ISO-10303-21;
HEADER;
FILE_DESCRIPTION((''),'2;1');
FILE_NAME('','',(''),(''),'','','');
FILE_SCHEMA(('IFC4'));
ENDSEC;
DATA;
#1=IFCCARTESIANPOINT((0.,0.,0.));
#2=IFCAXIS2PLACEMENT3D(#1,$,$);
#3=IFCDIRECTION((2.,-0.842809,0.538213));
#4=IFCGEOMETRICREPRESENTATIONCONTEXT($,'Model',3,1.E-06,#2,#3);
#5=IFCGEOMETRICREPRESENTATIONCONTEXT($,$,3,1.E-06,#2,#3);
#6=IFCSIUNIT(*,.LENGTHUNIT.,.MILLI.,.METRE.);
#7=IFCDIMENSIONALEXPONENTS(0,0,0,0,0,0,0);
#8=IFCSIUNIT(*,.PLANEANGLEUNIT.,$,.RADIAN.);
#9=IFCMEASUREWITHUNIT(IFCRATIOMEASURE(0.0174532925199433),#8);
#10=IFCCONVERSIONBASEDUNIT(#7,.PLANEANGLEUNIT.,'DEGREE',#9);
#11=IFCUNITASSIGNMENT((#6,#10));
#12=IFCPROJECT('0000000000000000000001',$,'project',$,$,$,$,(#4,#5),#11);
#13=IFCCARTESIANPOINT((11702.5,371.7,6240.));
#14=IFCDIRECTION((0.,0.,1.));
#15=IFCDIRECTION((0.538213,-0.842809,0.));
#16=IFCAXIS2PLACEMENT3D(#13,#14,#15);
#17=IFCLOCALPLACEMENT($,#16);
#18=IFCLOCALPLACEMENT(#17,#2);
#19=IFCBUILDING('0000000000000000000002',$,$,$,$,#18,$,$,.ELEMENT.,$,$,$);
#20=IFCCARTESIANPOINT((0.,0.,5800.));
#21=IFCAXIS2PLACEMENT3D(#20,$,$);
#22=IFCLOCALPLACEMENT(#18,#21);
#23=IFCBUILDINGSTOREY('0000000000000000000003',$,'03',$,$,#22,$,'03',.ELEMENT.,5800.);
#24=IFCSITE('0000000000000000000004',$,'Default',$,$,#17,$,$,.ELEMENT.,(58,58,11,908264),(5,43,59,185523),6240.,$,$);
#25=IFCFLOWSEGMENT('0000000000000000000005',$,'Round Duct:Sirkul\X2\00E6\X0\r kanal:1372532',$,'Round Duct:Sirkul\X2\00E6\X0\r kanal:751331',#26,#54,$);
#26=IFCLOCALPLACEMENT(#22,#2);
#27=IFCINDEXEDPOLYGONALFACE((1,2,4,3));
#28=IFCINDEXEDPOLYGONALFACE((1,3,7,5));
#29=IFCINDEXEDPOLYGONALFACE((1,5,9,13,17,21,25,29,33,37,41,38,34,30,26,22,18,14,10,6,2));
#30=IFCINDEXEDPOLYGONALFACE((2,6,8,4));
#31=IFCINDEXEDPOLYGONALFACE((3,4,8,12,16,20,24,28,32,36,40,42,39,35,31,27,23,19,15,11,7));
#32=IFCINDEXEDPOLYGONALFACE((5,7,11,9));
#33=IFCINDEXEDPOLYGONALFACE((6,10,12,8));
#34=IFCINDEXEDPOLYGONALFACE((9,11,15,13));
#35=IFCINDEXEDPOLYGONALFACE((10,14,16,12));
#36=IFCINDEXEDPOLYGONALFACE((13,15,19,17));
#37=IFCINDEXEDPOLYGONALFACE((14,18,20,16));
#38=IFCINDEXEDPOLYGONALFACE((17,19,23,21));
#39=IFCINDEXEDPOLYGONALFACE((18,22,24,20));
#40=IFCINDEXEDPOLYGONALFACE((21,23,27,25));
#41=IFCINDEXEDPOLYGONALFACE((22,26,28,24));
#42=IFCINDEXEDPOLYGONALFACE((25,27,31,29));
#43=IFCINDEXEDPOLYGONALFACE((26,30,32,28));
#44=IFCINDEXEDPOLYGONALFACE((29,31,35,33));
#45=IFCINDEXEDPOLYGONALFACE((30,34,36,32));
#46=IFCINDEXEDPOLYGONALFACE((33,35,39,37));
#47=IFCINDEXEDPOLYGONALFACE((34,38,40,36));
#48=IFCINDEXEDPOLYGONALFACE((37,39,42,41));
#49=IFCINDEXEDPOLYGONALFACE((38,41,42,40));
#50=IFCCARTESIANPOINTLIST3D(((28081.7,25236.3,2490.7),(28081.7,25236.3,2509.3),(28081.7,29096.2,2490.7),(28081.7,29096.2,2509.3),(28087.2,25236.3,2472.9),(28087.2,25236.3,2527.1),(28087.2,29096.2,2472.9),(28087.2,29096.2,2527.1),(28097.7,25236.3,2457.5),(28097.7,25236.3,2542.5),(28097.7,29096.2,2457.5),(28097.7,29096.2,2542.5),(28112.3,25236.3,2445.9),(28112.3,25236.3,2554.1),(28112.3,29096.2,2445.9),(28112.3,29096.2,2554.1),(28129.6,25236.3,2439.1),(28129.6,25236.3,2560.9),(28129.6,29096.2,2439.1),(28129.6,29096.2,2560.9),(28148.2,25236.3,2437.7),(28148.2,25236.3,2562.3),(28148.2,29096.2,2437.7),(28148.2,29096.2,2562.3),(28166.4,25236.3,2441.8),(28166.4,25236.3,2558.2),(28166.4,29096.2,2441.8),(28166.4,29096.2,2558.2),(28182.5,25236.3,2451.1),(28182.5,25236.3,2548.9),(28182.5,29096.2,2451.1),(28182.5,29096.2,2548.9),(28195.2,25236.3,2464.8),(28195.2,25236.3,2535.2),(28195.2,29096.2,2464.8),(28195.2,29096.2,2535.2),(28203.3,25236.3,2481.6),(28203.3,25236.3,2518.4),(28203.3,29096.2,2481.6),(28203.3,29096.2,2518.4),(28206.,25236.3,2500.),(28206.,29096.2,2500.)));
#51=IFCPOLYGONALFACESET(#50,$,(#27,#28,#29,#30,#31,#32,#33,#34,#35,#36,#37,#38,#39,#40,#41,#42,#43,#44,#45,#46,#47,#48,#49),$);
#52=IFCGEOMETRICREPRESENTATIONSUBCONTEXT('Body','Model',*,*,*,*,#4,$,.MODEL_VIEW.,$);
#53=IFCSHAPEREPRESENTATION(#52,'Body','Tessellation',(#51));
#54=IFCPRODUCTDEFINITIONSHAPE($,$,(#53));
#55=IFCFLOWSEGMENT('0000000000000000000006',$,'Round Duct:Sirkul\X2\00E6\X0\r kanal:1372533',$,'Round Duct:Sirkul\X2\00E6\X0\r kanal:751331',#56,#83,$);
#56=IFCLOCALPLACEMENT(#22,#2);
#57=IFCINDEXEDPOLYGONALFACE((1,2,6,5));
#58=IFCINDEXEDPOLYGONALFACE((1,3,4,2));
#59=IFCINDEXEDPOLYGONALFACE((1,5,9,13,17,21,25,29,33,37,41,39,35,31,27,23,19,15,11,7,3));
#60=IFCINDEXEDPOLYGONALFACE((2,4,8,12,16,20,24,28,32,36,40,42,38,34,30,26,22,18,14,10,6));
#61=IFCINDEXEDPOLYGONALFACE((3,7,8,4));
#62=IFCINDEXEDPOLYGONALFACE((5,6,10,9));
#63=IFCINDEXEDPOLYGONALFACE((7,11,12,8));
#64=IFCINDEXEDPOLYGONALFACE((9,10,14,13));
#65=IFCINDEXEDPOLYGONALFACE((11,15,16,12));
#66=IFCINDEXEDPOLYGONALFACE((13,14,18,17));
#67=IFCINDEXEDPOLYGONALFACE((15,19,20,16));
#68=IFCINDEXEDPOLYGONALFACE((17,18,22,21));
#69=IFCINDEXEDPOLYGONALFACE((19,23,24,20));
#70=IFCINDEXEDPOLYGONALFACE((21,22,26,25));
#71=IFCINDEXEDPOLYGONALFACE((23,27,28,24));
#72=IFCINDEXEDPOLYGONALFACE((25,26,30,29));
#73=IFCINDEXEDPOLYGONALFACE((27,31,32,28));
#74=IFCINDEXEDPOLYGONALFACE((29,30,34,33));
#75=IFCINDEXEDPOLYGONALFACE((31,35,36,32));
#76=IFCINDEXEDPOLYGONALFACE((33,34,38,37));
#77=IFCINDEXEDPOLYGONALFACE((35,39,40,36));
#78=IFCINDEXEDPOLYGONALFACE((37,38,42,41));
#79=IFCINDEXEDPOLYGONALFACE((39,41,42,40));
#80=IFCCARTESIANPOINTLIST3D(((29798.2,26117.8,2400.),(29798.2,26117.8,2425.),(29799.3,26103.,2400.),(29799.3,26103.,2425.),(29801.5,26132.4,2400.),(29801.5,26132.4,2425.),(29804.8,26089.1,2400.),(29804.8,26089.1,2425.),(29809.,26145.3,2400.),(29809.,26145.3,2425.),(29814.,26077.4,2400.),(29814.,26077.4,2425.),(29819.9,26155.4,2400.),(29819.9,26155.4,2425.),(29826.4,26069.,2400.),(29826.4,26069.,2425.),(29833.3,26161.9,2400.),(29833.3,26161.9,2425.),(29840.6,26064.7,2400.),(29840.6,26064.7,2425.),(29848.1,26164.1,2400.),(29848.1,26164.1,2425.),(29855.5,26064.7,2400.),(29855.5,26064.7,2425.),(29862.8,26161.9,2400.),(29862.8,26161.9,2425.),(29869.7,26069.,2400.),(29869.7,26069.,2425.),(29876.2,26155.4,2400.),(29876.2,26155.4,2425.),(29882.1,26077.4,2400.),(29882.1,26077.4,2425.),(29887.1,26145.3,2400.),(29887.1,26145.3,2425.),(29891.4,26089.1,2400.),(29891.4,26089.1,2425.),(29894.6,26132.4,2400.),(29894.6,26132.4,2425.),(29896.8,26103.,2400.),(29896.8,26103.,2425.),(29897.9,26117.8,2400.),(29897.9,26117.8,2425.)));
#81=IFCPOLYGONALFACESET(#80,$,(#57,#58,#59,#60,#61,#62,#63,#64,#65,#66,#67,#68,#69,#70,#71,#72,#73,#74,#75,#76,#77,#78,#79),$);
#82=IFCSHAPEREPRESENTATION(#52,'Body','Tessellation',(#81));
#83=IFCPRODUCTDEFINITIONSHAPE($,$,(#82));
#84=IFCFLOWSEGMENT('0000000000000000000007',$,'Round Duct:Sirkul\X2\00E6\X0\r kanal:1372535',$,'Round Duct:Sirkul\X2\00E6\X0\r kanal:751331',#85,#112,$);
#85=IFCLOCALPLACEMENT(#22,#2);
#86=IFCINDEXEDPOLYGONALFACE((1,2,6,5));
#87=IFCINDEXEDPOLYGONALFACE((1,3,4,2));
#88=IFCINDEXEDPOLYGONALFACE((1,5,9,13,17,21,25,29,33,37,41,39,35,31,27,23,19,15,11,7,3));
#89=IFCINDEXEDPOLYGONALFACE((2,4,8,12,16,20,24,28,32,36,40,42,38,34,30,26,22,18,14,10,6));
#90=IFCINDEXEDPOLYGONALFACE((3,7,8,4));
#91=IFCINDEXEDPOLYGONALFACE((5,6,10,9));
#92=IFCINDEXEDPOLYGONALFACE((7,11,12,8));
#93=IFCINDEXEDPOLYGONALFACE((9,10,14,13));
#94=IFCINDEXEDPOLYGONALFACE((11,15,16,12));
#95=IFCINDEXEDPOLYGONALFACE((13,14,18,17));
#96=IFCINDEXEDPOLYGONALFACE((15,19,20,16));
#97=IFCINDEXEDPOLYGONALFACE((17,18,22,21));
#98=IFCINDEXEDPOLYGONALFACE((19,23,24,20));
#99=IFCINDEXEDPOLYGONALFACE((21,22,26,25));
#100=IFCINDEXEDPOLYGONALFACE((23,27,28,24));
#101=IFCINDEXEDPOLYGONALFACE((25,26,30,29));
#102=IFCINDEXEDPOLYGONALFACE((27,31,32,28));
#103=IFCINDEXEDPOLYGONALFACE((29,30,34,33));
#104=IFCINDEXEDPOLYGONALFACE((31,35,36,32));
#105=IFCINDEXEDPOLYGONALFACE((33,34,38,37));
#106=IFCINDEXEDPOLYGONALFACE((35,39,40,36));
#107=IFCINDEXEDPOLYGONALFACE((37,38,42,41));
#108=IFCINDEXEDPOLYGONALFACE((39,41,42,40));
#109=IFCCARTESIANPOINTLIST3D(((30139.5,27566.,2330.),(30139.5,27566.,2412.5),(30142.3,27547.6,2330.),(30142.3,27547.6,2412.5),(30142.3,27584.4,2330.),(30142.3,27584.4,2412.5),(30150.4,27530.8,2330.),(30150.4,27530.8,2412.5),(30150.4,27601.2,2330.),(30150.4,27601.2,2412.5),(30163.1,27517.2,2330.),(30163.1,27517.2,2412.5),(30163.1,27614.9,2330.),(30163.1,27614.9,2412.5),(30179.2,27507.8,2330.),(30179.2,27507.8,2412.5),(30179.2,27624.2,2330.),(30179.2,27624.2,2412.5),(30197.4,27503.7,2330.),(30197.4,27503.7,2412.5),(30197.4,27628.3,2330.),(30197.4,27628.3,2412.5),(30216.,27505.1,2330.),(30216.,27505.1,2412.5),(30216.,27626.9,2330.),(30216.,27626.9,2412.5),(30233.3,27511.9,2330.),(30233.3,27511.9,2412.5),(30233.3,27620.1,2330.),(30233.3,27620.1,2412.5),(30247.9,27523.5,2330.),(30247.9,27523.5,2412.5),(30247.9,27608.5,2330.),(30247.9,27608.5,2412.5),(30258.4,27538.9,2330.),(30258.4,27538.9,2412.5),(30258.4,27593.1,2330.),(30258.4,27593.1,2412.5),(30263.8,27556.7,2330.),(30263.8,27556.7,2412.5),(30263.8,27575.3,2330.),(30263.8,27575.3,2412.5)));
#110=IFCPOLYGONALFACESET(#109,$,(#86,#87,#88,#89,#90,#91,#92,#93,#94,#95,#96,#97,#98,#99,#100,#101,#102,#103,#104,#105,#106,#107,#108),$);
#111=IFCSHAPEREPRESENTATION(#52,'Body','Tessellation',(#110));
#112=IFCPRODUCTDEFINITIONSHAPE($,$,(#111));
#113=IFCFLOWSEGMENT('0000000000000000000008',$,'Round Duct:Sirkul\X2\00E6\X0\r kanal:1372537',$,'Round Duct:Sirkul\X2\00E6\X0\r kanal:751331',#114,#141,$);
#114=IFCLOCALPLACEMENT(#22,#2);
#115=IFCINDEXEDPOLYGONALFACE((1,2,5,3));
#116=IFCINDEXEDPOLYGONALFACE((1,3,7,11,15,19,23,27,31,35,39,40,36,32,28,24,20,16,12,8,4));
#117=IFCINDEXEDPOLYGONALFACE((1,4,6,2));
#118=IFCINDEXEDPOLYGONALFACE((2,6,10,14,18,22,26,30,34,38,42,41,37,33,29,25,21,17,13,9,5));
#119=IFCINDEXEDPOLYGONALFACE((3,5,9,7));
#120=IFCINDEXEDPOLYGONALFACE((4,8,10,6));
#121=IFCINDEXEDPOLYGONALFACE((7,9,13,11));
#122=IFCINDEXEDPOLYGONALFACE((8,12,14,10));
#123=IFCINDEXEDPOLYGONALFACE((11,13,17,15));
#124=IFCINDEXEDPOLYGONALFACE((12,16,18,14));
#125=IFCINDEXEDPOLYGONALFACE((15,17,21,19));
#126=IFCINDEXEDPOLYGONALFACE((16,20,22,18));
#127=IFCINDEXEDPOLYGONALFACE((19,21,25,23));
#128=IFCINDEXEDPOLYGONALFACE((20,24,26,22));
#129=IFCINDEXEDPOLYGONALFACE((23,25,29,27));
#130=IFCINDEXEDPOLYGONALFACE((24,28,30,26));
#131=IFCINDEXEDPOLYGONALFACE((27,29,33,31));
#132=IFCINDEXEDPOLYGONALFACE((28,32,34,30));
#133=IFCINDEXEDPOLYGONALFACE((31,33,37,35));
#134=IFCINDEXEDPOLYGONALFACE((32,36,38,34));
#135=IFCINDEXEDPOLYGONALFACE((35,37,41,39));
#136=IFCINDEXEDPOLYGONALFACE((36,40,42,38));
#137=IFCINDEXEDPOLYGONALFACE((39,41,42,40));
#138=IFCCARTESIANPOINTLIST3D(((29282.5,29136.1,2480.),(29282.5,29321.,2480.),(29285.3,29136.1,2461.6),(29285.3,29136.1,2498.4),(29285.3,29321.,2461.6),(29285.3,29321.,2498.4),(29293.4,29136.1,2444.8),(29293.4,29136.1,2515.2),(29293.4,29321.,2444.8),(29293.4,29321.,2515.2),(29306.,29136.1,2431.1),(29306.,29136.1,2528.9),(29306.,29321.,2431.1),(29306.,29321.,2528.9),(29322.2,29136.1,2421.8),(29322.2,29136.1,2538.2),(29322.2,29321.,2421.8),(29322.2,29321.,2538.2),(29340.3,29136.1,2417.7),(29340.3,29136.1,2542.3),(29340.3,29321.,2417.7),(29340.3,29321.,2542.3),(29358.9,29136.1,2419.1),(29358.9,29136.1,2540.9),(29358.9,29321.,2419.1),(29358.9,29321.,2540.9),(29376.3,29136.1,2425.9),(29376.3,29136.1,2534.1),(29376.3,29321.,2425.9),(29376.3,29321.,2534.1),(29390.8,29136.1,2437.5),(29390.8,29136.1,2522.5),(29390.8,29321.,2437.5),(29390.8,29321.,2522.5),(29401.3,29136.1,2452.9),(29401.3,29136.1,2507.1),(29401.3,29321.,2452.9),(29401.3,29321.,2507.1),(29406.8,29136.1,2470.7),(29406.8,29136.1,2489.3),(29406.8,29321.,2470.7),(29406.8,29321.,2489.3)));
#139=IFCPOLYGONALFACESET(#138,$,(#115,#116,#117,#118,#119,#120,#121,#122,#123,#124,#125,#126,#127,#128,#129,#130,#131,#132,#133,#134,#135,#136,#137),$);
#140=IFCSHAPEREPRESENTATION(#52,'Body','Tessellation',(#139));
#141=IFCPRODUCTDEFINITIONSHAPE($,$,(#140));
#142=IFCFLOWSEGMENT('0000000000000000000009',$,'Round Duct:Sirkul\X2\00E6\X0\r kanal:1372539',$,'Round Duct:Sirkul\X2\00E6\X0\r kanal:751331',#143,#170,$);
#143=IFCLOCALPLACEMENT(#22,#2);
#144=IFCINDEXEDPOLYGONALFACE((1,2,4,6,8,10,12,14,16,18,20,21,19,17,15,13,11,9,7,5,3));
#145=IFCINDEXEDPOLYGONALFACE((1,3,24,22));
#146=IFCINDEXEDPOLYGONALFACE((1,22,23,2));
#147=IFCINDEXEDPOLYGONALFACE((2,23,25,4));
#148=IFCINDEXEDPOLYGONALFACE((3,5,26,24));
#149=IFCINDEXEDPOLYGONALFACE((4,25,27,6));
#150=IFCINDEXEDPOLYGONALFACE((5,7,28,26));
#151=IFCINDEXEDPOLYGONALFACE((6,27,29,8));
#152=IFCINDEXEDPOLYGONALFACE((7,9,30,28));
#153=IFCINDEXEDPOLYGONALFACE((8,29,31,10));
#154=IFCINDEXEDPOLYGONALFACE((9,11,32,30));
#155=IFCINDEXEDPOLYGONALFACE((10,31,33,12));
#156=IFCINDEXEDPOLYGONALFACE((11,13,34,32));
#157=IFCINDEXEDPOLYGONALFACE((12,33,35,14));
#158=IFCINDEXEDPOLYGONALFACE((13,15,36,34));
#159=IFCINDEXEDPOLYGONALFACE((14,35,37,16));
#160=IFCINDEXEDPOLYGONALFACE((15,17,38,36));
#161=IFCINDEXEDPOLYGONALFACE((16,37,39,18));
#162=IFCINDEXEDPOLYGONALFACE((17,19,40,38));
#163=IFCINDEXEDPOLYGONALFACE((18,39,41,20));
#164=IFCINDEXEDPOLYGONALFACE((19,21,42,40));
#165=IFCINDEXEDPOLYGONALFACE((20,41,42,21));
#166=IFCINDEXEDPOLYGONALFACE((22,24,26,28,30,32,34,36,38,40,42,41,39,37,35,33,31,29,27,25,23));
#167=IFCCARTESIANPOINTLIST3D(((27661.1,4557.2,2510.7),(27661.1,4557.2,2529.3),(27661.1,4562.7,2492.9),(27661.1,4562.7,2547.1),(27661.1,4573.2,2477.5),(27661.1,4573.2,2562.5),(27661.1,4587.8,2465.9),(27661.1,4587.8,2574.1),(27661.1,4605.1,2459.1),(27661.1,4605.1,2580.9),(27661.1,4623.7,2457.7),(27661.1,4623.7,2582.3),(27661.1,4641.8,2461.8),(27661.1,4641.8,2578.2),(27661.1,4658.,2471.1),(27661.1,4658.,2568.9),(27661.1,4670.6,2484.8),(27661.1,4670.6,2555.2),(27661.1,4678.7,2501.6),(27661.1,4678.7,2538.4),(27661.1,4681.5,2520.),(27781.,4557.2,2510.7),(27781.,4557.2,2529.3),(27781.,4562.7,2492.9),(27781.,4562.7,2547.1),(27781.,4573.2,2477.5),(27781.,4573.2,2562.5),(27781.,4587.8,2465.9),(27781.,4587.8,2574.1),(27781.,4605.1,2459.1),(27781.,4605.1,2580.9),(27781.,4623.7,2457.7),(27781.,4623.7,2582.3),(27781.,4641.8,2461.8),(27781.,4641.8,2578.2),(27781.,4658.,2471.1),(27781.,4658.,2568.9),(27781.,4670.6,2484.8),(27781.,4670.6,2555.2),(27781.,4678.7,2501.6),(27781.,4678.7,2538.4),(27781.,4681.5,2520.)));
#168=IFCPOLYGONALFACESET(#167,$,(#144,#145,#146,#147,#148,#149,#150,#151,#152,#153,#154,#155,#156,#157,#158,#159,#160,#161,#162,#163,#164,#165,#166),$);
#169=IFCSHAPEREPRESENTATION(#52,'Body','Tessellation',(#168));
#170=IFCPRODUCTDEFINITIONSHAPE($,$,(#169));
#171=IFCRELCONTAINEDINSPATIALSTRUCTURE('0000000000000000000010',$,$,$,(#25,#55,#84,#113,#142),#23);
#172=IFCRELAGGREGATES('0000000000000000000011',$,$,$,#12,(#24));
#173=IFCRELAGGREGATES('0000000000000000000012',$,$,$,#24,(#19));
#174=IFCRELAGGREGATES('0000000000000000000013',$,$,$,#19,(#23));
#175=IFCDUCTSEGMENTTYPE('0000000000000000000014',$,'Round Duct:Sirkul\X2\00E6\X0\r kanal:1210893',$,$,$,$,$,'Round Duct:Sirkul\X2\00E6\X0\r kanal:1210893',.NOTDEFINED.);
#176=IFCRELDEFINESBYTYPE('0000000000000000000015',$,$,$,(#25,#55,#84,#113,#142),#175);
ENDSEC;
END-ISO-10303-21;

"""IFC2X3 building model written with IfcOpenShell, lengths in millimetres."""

from ifc_helpers import new_model, entity, si_unit, converted_unit, direction, frame, frame_2d, origin, origin_2d_with_axis, place, context, subcontext, project, spatial, circle, extrude, type_object, element, save


model = new_model("IFC2X3")

# Units and contexts
model_context = context("Model", 3, precision=1e-06, world=origin(), true_north=direction((2.0, -0.842809, 0.538213)))
context_of_model = context(None, 3, precision=1e-06, world=origin(), true_north=direction((2.0, -0.842809, 0.538213)))
body_context = subcontext(model_context, "Body", "Model", "MODEL_VIEW")
ifc_project = project(units=[si_unit("LENGTHUNIT", "METRE", prefix="MILLI"), converted_unit("PLANEANGLEUNIT", "DEGREE", entity("IfcRatioMeasure", 0.0174532925199433), si_unit("PLANEANGLEUNIT", "RADIAN"), dimensions=[0, 0, 0, 0, 0, 0, 0])], contexts=[model_context, context_of_model])

# Site, building, storey
site_placement = place(None, frame((11702.5, 371.7, 6240.0), z_axis=(0.0, 0.0, 1.0), x_axis=(0.538213, -0.842809, 0.0)))
site = spatial("IfcSite", under=ifc_project, at=site_placement, Name="Default", CompositionType="ELEMENT", RefLatitude=(58, 58, 11, 908264), RefLongitude=(5, 43, 59, 185523), RefElevation=6240.0)
building_placement = place(site_placement, origin())
building = spatial("IfcBuilding", under=site, at=building_placement, CompositionType="ELEMENT")
storey_placement = place(building_placement, frame((0.0, 0.0, 5800.0)))
storey = spatial("IfcBuildingStorey", under=building, at=storey_placement, Name="03", LongName="03", CompositionType="ELEMENT", Elevation=5800.0)

# Flow segments
duct_segment_type_1 = type_object("IfcDuctSegmentType", Name="Round Duct:Sirkulær kanal:1210893", ElementType="Round Duct:Sirkulær kanal:1210893", PredefinedType="NOTDEFINED")
flow_segment_1_placement = place(storey_placement, origin())
element("IfcFlowSegment", 1, at=flow_segment_1_placement, inside=storey, type_object=duct_segment_type_1, Name="Round Duct:Sirkulær kanal:1372532", ObjectType="Round Duct:Sirkulær kanal:751331", context=body_context, shape_type="SweptSolid", body=[
    extrude(circle(Radius=62.5, at=frame_2d((0.0, 0.0), x_axis=(1.0, 0.0))), frame((28143.5, 25236.3, 2500.0), z_axis=(0.0, 1.0, 0.0), x_axis=(1.0, 0.0, 0.0)), (0.0, 0.0, 1.0), 3859.9),
])
flow_segment_2_placement = place(storey_placement, origin())
element("IfcFlowSegment", 2, at=flow_segment_2_placement, inside=storey, type_object=duct_segment_type_1, Name="Round Duct:Sirkulær kanal:1372533", ObjectType="Round Duct:Sirkulær kanal:751331", context=body_context, shape_type="SweptSolid", body=[
    extrude(circle(Radius=50.0, at=origin_2d_with_axis()), frame((29848.1, 26114.1, 2400.0), z_axis=(0.0, 0.0, 1.0), x_axis=(0.0, 1.0, 0.0)), (0.0, 0.0, 1.0), 25.0),
])
flow_segment_3_placement = place(storey_placement, origin())
element("IfcFlowSegment", 3, at=flow_segment_3_placement, inside=storey, type_object=duct_segment_type_1, Name="Round Duct:Sirkulær kanal:1372535", ObjectType="Round Duct:Sirkulær kanal:751331", context=body_context, shape_type="SweptSolid", body=[
    extrude(circle(Radius=62.5, at=frame_2d((0.0, 0.0), x_axis=(1.0, 0.0))), frame((30202.0, 27566.0, 2330.0), z_axis=(0.0, 0.0, 1.0), x_axis=(-1.0, 0.0, 0.0)), (0.0, 0.0, 1.0), 82.5),
])
flow_segment_4_placement = place(storey_placement, origin())
element("IfcFlowSegment", 4, at=flow_segment_4_placement, inside=storey, type_object=duct_segment_type_1, Name="Round Duct:Sirkulær kanal:1372537", ObjectType="Round Duct:Sirkulær kanal:751331", context=body_context, shape_type="SweptSolid", body=[
    extrude(circle(Radius=62.5, at=frame_2d((0.0, 0.0), x_axis=(1.0, 0.0))), frame((29345.0, 29136.1, 2480.0), z_axis=(0.0, 1.0, 0.0), x_axis=(-1.0, 0.0, 0.0)), (0.0, 0.0, 1.0), 184.9),
])
flow_segment_5_placement = place(storey_placement, origin())
element("IfcFlowSegment", 5, at=flow_segment_5_placement, inside=storey, type_object=duct_segment_type_1, Name="Round Duct:Sirkulær kanal:1372539", ObjectType="Round Duct:Sirkulær kanal:751331", context=body_context, shape_type="SweptSolid", body=[
    extrude(circle(Radius=62.5, at=frame_2d((0.0, 0.0), x_axis=(1.0, 0.0))), frame((27661.1, 4619.0, 2520.0), z_axis=(1.0, 0.0, 0.0), x_axis=(0.0, 1.0, 0.0)), (0.0, 0.0, 1.0), 119.9),
])

save(model, "model.ifc")
